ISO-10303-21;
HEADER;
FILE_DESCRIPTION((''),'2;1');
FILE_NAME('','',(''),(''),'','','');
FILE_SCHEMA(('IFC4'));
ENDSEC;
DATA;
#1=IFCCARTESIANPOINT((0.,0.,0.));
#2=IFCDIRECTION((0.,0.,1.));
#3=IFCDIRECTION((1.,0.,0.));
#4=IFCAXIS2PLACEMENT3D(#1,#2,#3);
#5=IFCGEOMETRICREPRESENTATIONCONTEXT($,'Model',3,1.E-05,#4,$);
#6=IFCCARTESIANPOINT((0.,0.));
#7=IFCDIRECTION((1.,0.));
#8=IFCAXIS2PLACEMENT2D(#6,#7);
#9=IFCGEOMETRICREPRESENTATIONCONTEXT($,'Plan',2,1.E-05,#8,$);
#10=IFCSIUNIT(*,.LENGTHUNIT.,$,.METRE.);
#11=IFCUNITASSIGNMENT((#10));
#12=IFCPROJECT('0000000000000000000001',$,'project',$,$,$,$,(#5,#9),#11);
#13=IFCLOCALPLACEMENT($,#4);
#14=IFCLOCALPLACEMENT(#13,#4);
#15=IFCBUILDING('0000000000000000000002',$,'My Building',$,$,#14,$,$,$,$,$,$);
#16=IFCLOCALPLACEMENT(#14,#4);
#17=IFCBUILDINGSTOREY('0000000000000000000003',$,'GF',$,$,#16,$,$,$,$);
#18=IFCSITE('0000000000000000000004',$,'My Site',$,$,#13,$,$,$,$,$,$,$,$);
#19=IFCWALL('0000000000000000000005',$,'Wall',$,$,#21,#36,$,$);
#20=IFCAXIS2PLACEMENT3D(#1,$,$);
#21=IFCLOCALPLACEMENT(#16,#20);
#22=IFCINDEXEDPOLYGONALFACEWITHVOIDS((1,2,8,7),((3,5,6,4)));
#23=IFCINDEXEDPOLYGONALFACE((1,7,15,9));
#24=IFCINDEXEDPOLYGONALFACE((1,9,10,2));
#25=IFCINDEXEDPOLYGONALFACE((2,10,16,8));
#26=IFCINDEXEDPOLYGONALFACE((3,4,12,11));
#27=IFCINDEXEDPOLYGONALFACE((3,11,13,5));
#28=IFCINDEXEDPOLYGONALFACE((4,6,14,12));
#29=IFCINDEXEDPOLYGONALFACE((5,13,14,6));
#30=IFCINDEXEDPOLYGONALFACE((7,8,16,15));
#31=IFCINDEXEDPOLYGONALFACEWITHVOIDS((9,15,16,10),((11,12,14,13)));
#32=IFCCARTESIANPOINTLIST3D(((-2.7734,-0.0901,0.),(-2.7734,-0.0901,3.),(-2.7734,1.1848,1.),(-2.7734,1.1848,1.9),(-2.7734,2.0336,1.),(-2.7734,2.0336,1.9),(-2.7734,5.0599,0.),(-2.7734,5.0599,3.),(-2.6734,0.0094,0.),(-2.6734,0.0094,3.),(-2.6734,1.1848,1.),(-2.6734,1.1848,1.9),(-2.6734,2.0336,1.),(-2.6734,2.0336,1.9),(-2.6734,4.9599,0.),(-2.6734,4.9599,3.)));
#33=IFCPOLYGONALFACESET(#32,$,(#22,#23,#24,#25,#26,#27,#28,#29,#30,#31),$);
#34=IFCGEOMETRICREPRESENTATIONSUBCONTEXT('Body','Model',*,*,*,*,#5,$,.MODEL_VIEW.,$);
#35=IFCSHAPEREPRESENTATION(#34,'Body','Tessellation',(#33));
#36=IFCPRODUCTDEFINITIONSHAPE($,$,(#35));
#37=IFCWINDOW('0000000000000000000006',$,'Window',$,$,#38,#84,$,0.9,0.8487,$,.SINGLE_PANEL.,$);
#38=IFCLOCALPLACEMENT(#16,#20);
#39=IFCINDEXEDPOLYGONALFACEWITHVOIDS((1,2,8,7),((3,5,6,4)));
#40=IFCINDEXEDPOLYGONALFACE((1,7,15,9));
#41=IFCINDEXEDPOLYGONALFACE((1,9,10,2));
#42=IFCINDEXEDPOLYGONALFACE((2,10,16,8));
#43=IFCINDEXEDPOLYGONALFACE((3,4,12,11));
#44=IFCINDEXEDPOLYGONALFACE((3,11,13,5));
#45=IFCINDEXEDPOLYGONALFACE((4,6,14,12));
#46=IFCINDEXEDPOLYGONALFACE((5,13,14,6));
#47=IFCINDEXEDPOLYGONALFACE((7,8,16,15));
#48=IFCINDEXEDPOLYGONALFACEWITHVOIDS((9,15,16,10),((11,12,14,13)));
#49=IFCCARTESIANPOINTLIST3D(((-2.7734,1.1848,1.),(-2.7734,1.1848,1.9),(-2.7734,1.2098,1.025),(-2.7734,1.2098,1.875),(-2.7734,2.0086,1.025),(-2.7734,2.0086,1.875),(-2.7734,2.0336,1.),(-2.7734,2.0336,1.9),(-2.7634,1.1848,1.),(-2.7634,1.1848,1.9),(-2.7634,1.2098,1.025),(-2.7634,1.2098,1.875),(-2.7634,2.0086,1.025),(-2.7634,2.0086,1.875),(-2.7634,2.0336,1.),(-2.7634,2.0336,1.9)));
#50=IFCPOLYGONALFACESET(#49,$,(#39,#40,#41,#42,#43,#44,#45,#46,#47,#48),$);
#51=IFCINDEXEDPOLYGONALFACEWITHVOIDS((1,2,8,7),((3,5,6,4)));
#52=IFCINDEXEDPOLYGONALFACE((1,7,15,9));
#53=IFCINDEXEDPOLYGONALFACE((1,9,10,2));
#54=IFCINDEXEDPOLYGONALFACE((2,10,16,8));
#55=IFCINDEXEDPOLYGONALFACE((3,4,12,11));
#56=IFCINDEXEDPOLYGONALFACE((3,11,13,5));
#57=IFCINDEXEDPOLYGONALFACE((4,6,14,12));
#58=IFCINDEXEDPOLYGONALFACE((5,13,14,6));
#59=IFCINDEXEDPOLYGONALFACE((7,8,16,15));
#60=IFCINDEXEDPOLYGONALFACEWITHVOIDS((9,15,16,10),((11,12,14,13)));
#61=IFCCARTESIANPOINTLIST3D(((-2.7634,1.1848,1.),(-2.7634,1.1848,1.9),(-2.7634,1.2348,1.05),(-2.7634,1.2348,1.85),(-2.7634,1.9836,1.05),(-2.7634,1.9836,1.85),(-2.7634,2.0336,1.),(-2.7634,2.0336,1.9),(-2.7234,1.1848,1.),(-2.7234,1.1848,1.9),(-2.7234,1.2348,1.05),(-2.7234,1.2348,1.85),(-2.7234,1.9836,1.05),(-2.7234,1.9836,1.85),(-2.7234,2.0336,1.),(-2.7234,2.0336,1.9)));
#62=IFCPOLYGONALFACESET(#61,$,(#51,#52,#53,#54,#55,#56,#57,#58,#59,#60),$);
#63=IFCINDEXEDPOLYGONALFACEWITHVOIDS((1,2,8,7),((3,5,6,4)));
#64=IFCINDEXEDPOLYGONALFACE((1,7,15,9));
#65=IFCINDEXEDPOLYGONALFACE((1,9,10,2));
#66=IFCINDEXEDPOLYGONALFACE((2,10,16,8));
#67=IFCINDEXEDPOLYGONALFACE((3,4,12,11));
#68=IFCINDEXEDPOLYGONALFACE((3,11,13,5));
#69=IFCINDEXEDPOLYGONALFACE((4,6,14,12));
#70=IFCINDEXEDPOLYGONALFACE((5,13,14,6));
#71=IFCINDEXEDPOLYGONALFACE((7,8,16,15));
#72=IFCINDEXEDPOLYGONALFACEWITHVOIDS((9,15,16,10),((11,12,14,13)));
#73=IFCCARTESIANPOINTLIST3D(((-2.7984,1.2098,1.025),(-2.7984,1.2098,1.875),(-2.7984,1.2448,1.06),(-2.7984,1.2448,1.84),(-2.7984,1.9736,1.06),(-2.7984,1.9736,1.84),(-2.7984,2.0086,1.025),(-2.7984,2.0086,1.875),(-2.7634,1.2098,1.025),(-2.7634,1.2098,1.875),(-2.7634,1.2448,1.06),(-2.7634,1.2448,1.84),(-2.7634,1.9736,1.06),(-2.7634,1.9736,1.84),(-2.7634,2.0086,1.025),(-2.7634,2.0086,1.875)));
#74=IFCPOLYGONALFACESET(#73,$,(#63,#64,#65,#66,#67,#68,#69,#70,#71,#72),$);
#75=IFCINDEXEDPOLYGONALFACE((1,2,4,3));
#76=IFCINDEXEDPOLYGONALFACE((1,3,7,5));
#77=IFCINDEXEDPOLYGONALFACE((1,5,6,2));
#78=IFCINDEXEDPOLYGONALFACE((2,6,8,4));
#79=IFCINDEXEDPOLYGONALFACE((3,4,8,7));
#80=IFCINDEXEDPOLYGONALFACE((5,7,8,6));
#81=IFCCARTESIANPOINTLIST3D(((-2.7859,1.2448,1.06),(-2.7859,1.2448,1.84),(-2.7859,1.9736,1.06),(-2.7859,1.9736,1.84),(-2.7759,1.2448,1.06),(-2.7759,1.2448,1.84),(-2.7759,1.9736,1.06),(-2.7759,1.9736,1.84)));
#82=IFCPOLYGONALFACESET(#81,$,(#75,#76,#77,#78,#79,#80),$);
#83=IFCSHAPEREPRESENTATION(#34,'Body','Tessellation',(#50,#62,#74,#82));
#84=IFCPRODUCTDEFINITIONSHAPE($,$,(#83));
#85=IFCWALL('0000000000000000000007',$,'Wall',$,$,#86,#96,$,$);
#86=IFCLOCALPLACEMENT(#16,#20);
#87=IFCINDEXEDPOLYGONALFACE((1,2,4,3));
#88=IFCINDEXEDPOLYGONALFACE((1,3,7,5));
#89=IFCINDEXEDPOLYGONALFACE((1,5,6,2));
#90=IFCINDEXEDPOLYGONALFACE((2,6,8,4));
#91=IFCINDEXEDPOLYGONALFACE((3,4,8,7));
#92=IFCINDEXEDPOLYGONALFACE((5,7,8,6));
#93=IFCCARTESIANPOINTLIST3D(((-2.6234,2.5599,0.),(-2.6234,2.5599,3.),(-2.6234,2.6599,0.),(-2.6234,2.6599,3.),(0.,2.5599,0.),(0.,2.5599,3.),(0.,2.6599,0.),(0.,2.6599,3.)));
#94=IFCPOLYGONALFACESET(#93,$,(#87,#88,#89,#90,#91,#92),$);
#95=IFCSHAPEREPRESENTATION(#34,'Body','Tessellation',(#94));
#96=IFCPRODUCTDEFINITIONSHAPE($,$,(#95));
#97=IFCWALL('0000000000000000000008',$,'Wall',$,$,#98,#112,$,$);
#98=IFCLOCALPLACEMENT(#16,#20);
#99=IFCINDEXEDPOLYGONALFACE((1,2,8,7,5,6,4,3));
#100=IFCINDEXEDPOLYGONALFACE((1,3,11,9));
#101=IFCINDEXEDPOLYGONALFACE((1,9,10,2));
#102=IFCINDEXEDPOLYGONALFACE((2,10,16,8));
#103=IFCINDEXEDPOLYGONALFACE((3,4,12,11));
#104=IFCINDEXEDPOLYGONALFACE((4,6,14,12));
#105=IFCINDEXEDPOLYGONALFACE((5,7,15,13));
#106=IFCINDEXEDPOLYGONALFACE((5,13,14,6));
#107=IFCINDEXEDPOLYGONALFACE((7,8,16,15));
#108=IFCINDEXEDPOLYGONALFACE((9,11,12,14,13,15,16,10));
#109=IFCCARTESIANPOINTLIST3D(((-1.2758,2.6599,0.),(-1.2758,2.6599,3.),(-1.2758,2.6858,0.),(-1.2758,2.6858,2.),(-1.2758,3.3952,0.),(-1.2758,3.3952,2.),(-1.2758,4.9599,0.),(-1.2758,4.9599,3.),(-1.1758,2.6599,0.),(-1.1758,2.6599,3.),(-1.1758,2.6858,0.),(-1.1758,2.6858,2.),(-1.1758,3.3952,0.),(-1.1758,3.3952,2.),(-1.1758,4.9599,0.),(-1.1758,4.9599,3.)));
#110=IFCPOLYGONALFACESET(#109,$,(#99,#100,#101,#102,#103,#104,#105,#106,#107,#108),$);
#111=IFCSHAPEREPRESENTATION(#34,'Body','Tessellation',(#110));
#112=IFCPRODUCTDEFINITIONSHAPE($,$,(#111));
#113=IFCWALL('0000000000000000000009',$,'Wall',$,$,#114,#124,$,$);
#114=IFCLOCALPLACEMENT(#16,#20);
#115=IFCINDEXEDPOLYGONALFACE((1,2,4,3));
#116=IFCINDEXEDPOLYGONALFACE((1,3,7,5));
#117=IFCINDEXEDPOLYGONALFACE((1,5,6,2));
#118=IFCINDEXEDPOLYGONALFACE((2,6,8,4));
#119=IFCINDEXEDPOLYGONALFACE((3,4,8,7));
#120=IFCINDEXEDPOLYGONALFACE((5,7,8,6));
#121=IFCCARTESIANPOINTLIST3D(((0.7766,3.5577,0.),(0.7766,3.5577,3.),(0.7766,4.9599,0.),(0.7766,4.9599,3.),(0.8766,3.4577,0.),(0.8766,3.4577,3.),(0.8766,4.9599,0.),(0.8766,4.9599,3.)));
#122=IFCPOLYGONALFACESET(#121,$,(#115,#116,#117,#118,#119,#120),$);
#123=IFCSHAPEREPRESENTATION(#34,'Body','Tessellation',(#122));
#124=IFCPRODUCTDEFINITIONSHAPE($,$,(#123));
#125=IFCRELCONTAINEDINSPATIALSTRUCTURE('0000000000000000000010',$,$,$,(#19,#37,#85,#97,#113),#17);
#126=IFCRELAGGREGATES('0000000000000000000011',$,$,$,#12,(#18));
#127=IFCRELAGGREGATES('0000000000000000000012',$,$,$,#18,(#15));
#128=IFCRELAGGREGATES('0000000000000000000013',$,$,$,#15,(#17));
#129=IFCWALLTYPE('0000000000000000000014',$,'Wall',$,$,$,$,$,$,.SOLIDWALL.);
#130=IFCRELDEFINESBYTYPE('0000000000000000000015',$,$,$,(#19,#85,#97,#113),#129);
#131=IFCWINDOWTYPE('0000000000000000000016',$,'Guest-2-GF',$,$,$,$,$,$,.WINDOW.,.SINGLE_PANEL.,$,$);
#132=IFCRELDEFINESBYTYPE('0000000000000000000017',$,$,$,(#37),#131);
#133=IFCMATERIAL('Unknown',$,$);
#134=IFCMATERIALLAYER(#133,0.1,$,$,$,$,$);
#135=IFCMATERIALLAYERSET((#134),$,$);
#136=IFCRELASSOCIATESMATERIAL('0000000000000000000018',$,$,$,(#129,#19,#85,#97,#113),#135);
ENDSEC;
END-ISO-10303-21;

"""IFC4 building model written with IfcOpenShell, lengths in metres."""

from ifc_helpers import new_model, entity, si_unit, frame, origin_with_axes, origin_2d_with_axis, place, context, subcontext, project, spatial, line, indexed_curve, outline, extrude, shape, source, transform, mapped, material, layer, layer_set, layer_usage, type_object, type_shapes, element, fill, save


model = new_model("IFC4")

# Units and contexts
model_context = context("Model", 3, precision=1e-05, world=origin_with_axes())
plan_context = context("Plan", 2, precision=1e-05, world=origin_2d_with_axis())
body_context_1 = subcontext(model_context, "Body", "Model", "MODEL_VIEW")
body_context_2 = subcontext(plan_context, "Body", "Plan", "PLAN_VIEW")
ifc_project = project(units=[si_unit("LENGTHUNIT", "METRE")], contexts=[model_context, plan_context])

# Site, building, storey
site_placement = place(None, origin_with_axes())
site = spatial("IfcSite", under=ifc_project, at=site_placement, Name="My Site")
building_placement = place(site_placement, origin_with_axes())
building = spatial("IfcBuilding", under=site, at=building_placement, Name="My Building")
storey_placement = place(building_placement, origin_with_axes())
storey = spatial("IfcBuildingStorey", under=building, at=storey_placement, Name="GF")

# Shared definitions
ifc_material = material(Name="Unknown")
ifc_layer = layer(ifc_material, 0.1)
ifc_layer_set = layer_set([ifc_layer])
wall_type = type_object("IfcWallType", Name="Wall", PredefinedType="SOLIDWALL", material=ifc_layer_set)

# Wall, opening, window
ifc_layer_usage_1 = layer_usage(ifc_layer_set, "AXIS2", "POSITIVE", 0.0)
wall_1_placement = place(storey_placement, frame((-2.7734, 5.0599, 0.0), z_axis=(0.0, 0.0, 1.0), x_axis=(0.0, -1.0, 0.0)))
wall_1 = element("IfcWall", 1, at=wall_1_placement, inside=storey, type_object=wall_type, material=ifc_layer_usage_1, Name="Wall", context=body_context_1, shape_type="SweptSolid", body=[
    extrude(outline(indexed_curve([(0.0, 0.0), (0.1, 0.1), (5.0504, 0.1), (5.15, 0.0)], segments=[line(1, 2, 3, 4, 1)])), origin_with_axes(), (0.0, 0.0, 1.0), 3.0),
])
shared_shape_1 = source(origin_with_axes(), body_context_1, "Body", "SweptSolid", [
    extrude(outline(indexed_curve([(0.0, 0.0), (0.8487, 0.0), (0.8487, 0.9), (0.0, 0.9)], segments=[line(1, 2, 3, 4, 1)])), frame((0.0, -0.6, 0.0), z_axis=(0.0, -1.0, 0.0), x_axis=(1.0, 0.0, 0.0)), (0.0, 0.0, -1.0), 1.2),
])
opening_1_placement = place(wall_1_placement, frame((3.875, 0.1, 1.0), z_axis=(0.0, 0.0, 1.0), x_axis=(-1.0, 0.0, 0.0)))
opening_1 = element("IfcOpeningElement", 2, at=opening_1_placement, cuts=wall_1, PredefinedType="OPENING", context=body_context_1, shape_type="MappedRepresentation", body=[
    mapped(shared_shape_1, transform((0.0, 0.0, 0.0), x_axis=(1.0, 0.0, 0.0), y_axis=(0.0, 1.0, 0.0), z_axis=(0.0, 0.0, 1.0), scale=1.0)),
])
window_type_1 = type_object("IfcWindowType", Name="Guest-2-GF", PartitioningType="SINGLE_PANEL", PredefinedType="WINDOW")
shared_shape_2 = source(origin_with_axes(), body_context_1, "Body", "SweptSolid", [
    extrude(outline(indexed_curve([(0.0, 0.0), (0.8487, 0.0), (0.8487, 0.9), (0.0, 0.9)], segments=[line(1, 2, 3, 4, 1)]), holes=[indexed_curve([(0.025, 0.025), (0.8237, 0.025), (0.8237, 0.875), (0.025, 0.875)], segments=[line(1, 2, 3, 4, 1)])]), frame((0.0, 0.09, 0.0), z_axis=(0.0, -1.0, 0.0), x_axis=(1.0, 0.0, 0.0)), (0.0, 0.0, -1.0), 0.01),
    extrude(outline(indexed_curve([(0.0, 0.0), (0.8487, 0.0), (0.8487, 0.9), (0.0, 0.9)], segments=[line(1, 2, 3, 4, 1)]), holes=[indexed_curve([(0.05, 0.05), (0.7987, 0.05), (0.7987, 0.85), (0.05, 0.85)], segments=[line(1, 2, 3, 4, 1)])]), frame((0.0, 0.05, 0.0), z_axis=(0.0, -1.0, 0.0), x_axis=(1.0, 0.0, 0.0)), (0.0, 0.0, -1.0), 0.04),
    extrude(outline(indexed_curve([(0.0, 0.0), (0.7987, 0.0), (0.7987, 0.85), (0.0, 0.85)], segments=[line(1, 2, 3, 4, 1)]), holes=[indexed_curve([(0.035, 0.035), (0.7637, 0.035), (0.7637, 0.815), (0.035, 0.815)], segments=[line(1, 2, 3, 4, 1)])]), frame((0.025, 0.09, 0.025), z_axis=(0.0, -1.0, 0.0), x_axis=(1.0, 0.0, 0.0)), (0.0, 0.0, -1.0), 0.035),
    extrude(outline(indexed_curve([(0.035, 0.035), (0.7637, 0.035), (0.7637, 0.815), (0.035, 0.815)], segments=[line(1, 2, 3, 4, 1)])), frame((0.025, 0.1025, 0.025), z_axis=(0.0, -1.0, 0.0), x_axis=(1.0, 0.0, 0.0)), (0.0, 0.0, -1.0), 0.01),
])
shared_shape_3 = source(origin_with_axes(), body_context_2, "Body", "Curve2D", [
    entity("IfcIndexedPolyCurve", entity("IfcCartesianPointList2D", [[0.05, 0.05], [0.7987, 0.05]])),
    entity("IfcIndexedPolyCurve", entity("IfcCartesianPointList2D", [[0.0, 0.1], [0.025, 0.1], [0.025, 0.09], [0.05, 0.09], [0.05, 0.05], [0.0, 0.05]]), [entity("IfcLineIndex", [1, 2, 3, 4, 5, 6, 1])]),
    entity("IfcIndexedPolyCurve", entity("IfcCartesianPointList2D", [[0.8487, 0.1], [0.8237, 0.1], [0.8237, 0.09], [0.7987, 0.09], [0.7987, 0.05], [0.8487, 0.05]]), [entity("IfcLineIndex", [1, 2, 3, 4, 5, 6, 1])]),
    entity("IfcIndexedPolyCurve", entity("IfcCartesianPointList2D", [[0.025, 0.09], [0.06, 0.09], [0.06, 0.125], [0.025, 0.125]]), [entity("IfcLineIndex", [1, 2, 3, 4, 1])]),
    entity("IfcIndexedPolyCurve", entity("IfcCartesianPointList2D", [[0.8237, 0.09], [0.7887, 0.09], [0.7887, 0.125], [0.8237, 0.125]]), [entity("IfcLineIndex", [1, 2, 3, 4, 1])]),
    entity("IfcIndexedPolyCurve", entity("IfcCartesianPointList2D", [[0.06, 0.09], [0.7887, 0.09]])),
    entity("IfcIndexedPolyCurve", entity("IfcCartesianPointList2D", [[0.06, 0.125], [0.7887, 0.125]])),
    entity("IfcIndexedPolyCurve", entity("IfcCartesianPointList2D", [[0.06, 0.1075], [0.7887, 0.1075]])),
])
type_shapes(window_type_1, [shared_shape_2, shared_shape_3])
window_1_placement = place(opening_1_placement, frame((0.0, 0.0, 0.0), z_axis=(0.0, 0.0, 1.0), x_axis=(1.0, 0.0, 0.0)))
window_1 = element("IfcWindow", 3, at=window_1_placement, inside=storey, type_object=window_type_1, Name="Window", OverallHeight=0.9, OverallWidth=0.8487, PartitioningType="SINGLE_PANEL", shapes=[
    shape(body_context_1, "Body", "MappedRepresentation", [mapped(shared_shape_2, transform((0.0, 0.0, 0.0), x_axis=(1.0, 0.0, 0.0), y_axis=(0.0, 1.0, 0.0), z_axis=(0.0, 0.0, 1.0), scale=1.0))]),
    shape(body_context_2, "Body", "MappedRepresentation", [mapped(shared_shape_3, transform((0.0, 0.0, 0.0), x_axis=(1.0, 0.0, 0.0), y_axis=(0.0, 1.0, 0.0), z_axis=(0.0, 0.0, 1.0), scale=1.0))]),
])
fill(opening_1, window_1)

# Wall
ifc_layer_usage_2 = layer_usage(ifc_layer_set, "AXIS2", "POSITIVE", 0.0)
wall_2_placement = place(storey_placement, frame((0.0, 2.6599, 0.0), z_axis=(0.0, 0.0, 1.0), x_axis=(-1.0, 0.0, 0.0)))
element("IfcWall", 4, at=wall_2_placement, inside=storey, type_object=wall_type, material=ifc_layer_usage_2, Name="Wall", context=body_context_1, shape_type="SweptSolid", body=[
    extrude(outline(indexed_curve([(0.0, 0.0), (0.0, 0.1), (2.6234, 0.1), (2.6234, 0.0)], segments=[line(1, 2, 3, 4, 1)])), origin_with_axes(), (0.0, 0.0, 1.0), 3.0),
])

# Wall, opening
ifc_layer_usage_3 = layer_usage(ifc_layer_set, "AXIS2", "POSITIVE", 0.0)
wall_3_placement = place(storey_placement, frame((-1.1758, 2.6599, 0.0), z_axis=(0.0, 0.0, 1.0), x_axis=(0.0, 1.0, 0.0)))
wall_3 = element("IfcWall", 5, at=wall_3_placement, inside=storey, type_object=wall_type, material=ifc_layer_usage_3, Name="Wall", context=body_context_1, shape_type="SweptSolid", body=[
    extrude(outline(indexed_curve([(0.0, 0.0), (0.0, 0.1), (2.3, 0.1), (2.3, 0.0)], segments=[line(1, 2, 3, 4, 1)])), origin_with_axes(), (0.0, 0.0, 1.0), 3.0),
])
shared_shape_4 = source(origin_with_axes(), body_context_1, "Body", "SweptSolid", [
    extrude(outline(indexed_curve([(0.0, 0.0), (0.7094, 0.0), (0.7094, 2.0), (0.0, 2.0)], segments=[line(1, 2, 3, 4, 1)])), frame((0.0, -0.6, 0.0), z_axis=(0.0, -1.0, 0.0), x_axis=(1.0, 0.0, 0.0)), (0.0, 0.0, -1.0), 1.2),
])
opening_2_placement = place(wall_3_placement, frame((0.0259, 0.015, 0.0), z_axis=(0.0, 0.0, 1.0), x_axis=(1.0, 0.0, 0.0)))
element("IfcOpeningElement", 6, at=opening_2_placement, cuts=wall_3, PredefinedType="OPENING", context=body_context_1, shape_type="MappedRepresentation", body=[
    mapped(shared_shape_4, transform((0.0, 0.0, 0.0), x_axis=(1.0, 0.0, 0.0), y_axis=(0.0, 1.0, 0.0), z_axis=(0.0, 0.0, 1.0), scale=1.0)),
])

# Wall
ifc_layer_usage_4 = layer_usage(ifc_layer_set, "AXIS2", "POSITIVE", 0.0)
wall_4_placement = place(storey_placement, frame((0.7766, 4.9599, 0.0), z_axis=(0.0, 0.0, 1.0), x_axis=(0.0, -1.0, 0.0)))
element("IfcWall", 7, at=wall_4_placement, inside=storey, type_object=wall_type, material=ifc_layer_usage_4, Name="Wall", context=body_context_1, shape_type="SweptSolid", body=[
    extrude(outline(indexed_curve([(0.0, 0.0), (0.0, 0.1), (1.5022, 0.1), (1.4022, 0.0)], segments=[line(1, 2, 3, 4, 1)])), origin_with_axes(), (0.0, 0.0, 1.0), 3.0),
])

save(model, "model.ifc")
